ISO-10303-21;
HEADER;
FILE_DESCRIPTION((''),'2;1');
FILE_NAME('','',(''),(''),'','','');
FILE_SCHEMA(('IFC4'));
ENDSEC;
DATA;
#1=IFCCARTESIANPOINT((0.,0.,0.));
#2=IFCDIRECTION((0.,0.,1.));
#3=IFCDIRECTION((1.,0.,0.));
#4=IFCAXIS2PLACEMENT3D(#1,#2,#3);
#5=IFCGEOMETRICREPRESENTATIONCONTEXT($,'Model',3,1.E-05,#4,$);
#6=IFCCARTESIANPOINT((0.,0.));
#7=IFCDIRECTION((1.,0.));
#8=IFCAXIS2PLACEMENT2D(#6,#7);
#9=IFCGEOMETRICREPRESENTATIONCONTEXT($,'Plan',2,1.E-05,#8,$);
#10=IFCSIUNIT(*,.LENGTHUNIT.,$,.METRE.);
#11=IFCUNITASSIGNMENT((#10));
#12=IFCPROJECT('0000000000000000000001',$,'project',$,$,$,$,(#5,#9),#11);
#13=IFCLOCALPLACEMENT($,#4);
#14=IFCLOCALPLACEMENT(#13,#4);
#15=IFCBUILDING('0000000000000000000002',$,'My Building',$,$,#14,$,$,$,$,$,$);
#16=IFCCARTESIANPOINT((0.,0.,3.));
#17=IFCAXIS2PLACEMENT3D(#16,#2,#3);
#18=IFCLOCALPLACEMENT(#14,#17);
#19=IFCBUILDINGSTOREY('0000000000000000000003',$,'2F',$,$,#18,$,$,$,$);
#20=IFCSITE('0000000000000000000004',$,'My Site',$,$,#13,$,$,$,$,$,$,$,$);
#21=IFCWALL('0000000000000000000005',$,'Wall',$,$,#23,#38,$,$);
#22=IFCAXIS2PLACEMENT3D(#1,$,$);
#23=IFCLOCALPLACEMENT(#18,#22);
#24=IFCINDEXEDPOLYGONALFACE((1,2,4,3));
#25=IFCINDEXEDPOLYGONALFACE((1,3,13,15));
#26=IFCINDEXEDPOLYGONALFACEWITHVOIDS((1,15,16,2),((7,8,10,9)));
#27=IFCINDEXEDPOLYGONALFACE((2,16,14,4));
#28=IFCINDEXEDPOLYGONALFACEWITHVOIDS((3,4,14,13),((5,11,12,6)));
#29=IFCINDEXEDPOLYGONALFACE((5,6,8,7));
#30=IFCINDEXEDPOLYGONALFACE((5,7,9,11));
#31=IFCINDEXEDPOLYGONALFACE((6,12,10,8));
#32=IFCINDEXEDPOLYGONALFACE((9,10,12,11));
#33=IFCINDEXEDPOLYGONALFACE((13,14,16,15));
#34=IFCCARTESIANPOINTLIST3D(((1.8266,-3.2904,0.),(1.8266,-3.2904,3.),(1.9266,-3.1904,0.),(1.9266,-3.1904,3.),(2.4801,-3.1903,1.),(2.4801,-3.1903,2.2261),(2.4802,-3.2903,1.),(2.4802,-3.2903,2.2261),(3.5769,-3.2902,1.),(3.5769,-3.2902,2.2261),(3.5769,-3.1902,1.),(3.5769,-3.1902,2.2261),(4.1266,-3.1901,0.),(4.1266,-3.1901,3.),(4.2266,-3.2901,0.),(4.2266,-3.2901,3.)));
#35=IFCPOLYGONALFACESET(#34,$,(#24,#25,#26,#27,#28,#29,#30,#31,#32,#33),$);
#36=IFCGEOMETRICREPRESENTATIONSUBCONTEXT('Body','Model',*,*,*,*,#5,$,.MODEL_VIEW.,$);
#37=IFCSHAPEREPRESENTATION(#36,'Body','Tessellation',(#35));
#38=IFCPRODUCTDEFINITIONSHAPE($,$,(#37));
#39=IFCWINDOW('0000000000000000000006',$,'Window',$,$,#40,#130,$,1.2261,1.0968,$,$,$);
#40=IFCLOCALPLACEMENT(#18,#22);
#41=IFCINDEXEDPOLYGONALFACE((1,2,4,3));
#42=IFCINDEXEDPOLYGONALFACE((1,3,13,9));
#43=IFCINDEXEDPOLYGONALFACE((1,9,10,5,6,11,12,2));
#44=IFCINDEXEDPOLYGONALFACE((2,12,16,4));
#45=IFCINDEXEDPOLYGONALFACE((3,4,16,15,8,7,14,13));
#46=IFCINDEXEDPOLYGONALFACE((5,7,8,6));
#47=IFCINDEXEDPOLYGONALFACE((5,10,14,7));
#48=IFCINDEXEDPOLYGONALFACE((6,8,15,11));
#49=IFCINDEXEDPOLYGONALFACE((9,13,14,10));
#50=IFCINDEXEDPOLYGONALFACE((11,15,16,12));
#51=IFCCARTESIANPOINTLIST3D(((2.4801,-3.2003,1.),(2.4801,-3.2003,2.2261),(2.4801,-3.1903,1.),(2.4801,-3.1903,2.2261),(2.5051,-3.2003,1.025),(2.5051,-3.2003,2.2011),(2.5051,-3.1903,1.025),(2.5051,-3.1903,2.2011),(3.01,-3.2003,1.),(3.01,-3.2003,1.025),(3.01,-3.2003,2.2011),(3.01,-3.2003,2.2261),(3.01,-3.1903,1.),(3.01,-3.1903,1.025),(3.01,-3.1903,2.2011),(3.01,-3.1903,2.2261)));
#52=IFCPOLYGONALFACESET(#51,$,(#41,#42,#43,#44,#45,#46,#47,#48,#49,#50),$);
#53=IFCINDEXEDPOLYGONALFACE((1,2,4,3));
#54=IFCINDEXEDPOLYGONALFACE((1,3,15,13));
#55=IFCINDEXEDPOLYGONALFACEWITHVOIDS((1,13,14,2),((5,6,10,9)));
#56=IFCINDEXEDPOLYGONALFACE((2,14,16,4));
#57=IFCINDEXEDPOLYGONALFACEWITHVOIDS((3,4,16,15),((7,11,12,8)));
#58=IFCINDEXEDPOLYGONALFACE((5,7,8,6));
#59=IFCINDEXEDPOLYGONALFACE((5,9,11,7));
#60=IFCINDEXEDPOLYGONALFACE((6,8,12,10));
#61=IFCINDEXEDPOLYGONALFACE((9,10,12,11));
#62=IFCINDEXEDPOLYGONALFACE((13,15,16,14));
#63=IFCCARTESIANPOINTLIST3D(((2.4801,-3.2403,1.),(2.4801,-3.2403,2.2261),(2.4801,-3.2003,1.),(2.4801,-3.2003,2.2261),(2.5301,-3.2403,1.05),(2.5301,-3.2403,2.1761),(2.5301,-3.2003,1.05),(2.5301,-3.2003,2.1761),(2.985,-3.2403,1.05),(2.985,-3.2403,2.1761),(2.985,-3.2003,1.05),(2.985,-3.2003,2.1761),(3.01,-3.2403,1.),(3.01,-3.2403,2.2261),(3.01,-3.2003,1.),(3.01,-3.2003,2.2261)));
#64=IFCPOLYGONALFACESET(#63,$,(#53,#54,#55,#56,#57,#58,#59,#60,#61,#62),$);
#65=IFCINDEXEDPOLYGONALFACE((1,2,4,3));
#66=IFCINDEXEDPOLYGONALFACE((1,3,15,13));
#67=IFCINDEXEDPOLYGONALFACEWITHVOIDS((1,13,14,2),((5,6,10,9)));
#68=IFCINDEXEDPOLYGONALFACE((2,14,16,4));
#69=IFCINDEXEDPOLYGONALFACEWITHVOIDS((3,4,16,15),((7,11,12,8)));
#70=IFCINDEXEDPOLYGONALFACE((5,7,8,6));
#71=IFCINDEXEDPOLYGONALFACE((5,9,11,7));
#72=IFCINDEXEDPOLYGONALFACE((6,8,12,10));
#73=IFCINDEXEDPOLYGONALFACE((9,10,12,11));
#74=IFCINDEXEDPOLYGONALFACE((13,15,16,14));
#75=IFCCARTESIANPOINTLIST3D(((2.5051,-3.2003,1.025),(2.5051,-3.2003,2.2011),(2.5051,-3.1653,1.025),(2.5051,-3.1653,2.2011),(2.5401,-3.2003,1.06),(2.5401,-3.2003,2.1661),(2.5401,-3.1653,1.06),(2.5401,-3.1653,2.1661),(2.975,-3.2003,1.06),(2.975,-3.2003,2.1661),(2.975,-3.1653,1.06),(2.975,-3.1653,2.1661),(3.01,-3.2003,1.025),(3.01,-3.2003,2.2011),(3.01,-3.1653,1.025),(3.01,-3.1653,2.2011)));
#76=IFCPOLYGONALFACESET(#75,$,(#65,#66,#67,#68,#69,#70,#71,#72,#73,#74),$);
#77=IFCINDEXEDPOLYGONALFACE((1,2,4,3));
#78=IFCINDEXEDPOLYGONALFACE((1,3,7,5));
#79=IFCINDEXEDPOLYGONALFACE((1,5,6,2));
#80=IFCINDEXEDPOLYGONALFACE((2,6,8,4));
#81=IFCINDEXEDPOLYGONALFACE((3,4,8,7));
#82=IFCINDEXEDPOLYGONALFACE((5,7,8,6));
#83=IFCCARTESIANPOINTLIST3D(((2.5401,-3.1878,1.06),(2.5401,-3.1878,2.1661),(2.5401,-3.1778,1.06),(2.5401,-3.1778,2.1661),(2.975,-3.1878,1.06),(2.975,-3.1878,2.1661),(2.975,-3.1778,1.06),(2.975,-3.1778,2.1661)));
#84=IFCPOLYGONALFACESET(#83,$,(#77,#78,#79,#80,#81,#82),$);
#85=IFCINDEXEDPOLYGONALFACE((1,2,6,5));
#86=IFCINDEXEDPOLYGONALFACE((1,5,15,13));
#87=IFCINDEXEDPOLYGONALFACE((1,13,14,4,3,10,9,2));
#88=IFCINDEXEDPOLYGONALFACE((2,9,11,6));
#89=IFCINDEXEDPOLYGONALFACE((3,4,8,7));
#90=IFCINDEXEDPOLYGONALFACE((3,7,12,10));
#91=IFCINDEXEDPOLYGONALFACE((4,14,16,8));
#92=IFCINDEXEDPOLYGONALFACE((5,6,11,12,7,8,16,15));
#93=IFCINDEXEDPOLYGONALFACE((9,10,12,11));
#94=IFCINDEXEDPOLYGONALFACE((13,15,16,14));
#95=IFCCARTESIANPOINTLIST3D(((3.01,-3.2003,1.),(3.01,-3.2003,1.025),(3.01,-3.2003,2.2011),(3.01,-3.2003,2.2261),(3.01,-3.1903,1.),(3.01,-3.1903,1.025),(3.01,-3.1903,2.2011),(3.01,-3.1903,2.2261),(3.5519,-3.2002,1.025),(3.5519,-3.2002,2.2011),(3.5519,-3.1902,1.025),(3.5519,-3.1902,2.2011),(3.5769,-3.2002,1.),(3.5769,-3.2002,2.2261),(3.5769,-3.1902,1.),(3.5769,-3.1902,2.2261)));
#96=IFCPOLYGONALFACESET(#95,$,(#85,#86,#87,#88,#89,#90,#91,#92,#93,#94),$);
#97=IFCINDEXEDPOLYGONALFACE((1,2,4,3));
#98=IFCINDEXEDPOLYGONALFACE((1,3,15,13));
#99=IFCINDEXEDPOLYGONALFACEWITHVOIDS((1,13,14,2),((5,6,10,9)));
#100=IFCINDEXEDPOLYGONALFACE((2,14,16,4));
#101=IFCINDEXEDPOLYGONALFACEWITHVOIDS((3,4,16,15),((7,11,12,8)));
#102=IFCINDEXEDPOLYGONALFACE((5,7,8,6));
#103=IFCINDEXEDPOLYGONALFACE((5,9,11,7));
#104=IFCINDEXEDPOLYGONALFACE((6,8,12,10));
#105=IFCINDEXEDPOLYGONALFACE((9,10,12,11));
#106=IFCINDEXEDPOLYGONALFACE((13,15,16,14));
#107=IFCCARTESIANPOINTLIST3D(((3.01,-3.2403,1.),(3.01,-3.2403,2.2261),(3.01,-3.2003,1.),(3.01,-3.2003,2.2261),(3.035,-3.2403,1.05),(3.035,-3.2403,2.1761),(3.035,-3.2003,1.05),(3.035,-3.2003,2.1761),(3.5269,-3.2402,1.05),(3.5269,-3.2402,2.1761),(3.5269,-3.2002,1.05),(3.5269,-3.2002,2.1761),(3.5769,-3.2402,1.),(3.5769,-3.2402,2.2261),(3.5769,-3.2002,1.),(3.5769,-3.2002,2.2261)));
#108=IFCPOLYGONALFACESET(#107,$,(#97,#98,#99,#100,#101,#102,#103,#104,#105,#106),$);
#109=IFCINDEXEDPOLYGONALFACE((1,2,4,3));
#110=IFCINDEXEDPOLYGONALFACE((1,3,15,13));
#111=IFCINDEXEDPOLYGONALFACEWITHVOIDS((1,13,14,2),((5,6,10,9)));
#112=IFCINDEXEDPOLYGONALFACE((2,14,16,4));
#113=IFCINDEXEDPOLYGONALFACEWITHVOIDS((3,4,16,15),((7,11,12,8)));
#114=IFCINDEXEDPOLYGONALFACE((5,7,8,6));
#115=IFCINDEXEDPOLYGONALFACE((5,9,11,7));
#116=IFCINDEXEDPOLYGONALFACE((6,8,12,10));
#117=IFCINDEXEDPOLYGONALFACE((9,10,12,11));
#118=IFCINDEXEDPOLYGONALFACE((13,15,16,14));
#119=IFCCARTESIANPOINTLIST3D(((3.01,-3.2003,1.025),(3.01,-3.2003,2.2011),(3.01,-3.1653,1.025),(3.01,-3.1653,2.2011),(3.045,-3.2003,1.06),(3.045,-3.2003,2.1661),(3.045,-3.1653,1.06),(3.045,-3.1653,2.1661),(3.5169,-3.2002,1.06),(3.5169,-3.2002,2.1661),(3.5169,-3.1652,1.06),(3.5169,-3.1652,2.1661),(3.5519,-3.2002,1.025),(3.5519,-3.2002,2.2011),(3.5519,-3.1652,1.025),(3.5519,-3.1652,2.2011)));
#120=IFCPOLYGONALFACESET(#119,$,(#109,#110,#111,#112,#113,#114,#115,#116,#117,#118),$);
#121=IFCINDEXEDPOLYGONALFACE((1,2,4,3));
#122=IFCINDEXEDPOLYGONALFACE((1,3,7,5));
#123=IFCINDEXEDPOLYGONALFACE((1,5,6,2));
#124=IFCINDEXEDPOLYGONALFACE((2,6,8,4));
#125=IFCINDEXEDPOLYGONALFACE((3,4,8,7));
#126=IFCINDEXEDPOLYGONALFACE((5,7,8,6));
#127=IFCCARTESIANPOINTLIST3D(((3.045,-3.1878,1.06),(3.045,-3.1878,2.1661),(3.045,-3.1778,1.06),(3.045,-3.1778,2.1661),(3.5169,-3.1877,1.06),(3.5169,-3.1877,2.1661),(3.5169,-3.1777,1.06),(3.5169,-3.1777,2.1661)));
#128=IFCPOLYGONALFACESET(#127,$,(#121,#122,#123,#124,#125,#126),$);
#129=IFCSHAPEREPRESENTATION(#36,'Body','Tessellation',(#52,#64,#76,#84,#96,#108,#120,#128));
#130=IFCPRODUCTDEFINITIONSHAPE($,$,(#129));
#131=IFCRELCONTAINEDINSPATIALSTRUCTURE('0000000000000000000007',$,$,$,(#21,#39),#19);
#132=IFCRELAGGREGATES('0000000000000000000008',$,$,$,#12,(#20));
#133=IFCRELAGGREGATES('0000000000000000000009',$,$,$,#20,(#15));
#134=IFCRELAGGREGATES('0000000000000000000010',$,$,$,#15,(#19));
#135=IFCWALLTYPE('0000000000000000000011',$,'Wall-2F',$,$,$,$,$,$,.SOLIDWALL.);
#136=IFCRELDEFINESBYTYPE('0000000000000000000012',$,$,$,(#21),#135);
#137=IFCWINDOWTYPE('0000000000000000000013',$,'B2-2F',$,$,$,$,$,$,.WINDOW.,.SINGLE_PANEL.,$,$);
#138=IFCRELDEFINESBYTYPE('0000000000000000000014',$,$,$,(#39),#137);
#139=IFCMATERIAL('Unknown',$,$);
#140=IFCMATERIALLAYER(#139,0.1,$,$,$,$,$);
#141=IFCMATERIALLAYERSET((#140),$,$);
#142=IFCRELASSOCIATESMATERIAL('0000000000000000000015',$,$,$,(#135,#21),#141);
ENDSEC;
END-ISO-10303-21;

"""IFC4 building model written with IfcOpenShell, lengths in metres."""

from ifc_helpers import new_model, entity, si_unit, frame, origin_with_axes, origin_2d_with_axis, place, context, subcontext, project, spatial, line, indexed_curve, outline, extrude, shape, source, transform, mapped, material, layer, layer_set, layer_usage, type_object, type_shapes, element, fill, save


model = new_model("IFC4")

# Units and contexts
model_context = context("Model", 3, precision=1e-05, world=origin_with_axes())
plan_context = context("Plan", 2, precision=1e-05, world=origin_2d_with_axis())
body_context_1 = subcontext(model_context, "Body", "Model", "MODEL_VIEW")
body_context_2 = subcontext(plan_context, "Body", "Plan", "PLAN_VIEW")
ifc_project = project(units=[si_unit("LENGTHUNIT", "METRE")], contexts=[model_context, plan_context])

# Site, building, storey
site_placement = place(None, origin_with_axes())
site = spatial("IfcSite", under=ifc_project, at=site_placement, Name="My Site")
building_placement = place(site_placement, origin_with_axes())
building = spatial("IfcBuilding", under=site, at=building_placement, Name="My Building")
storey_placement = place(building_placement, frame((0.0, 0.0, 3.0), z_axis=(0.0, 0.0, 1.0), x_axis=(1.0, 0.0, 0.0)))
storey = spatial("IfcBuildingStorey", under=building, at=storey_placement, Name="2F")

# Shared definitions
ifc_material = material(Name="Unknown")

# Shared definitions
ifc_layer_1 = layer(ifc_material, 0.1)
ifc_layer_set_1 = layer_set([ifc_layer_1])
wall_type = type_object("IfcWallType", Name="Wall-2F", PredefinedType="SOLIDWALL", material=ifc_layer_set_1)

# Shared definitions
shared_shape_1 = source(origin_with_axes(), body_context_1, "Body", "SweptSolid", [
    extrude(outline(indexed_curve([(0.0, 0.0), (1.0968, 0.0), (1.0968, 1.2261), (0.0, 1.2261)], segments=[line(1, 2, 3, 4, 1)])), frame((0.0, -0.6, 0.0), z_axis=(0.0, -1.0, 0.0), x_axis=(1.0, 0.0, 0.0)), (0.0, 0.0, -1.0), 1.2),
])
window_type_1 = type_object("IfcWindowType", Name="B2-2F", PartitioningType="SINGLE_PANEL", PredefinedType="WINDOW")
shared_shape_2 = source(origin_with_axes(), body_context_1, "Body", "SweptSolid", [
    extrude(outline(indexed_curve([(0.5299, 0.0), (0.0, 0.0), (0.0, 1.2261), (0.5299, 1.2261), (0.5299, 1.2011), (0.025, 1.2011), (0.025, 0.025), (0.5299, 0.025)], segments=[line(1, 2, 3, 4, 5, 6, 7, 8, 1)])), frame((0.0, 0.09, 0.0), z_axis=(0.0, -1.0, 0.0), x_axis=(1.0, 0.0, 0.0)), (0.0, 0.0, -1.0), 0.01),
    extrude(outline(indexed_curve([(0.0, 0.0), (0.5299, 0.0), (0.5299, 1.2261), (0.0, 1.2261)], segments=[line(1, 2, 3, 4, 1)]), holes=[indexed_curve([(0.05, 0.05), (0.5049, 0.05), (0.5049, 1.1761), (0.05, 1.1761)], segments=[line(1, 2, 3, 4, 1)])]), frame((0.0, 0.05, 0.0), z_axis=(0.0, -1.0, 0.0), x_axis=(1.0, 0.0, 0.0)), (0.0, 0.0, -1.0), 0.04),
    extrude(outline(indexed_curve([(0.0, 0.0), (0.5049, 0.0), (0.5049, 1.1761), (0.0, 1.1761)], segments=[line(1, 2, 3, 4, 1)]), holes=[indexed_curve([(0.035, 0.035), (0.4699, 0.035), (0.4699, 1.1411), (0.035, 1.1411)], segments=[line(1, 2, 3, 4, 1)])]), frame((0.025, 0.09, 0.025), z_axis=(0.0, -1.0, 0.0), x_axis=(1.0, 0.0, 0.0)), (0.0, 0.0, -1.0), 0.035),
    extrude(outline(indexed_curve([(0.035, 0.035), (0.4699, 0.035), (0.4699, 1.1411), (0.035, 1.1411)], segments=[line(1, 2, 3, 4, 1)])), frame((0.025, 0.1025, 0.025), z_axis=(0.0, -1.0, 0.0), x_axis=(1.0, 0.0, 0.0)), (0.0, 0.0, -1.0), 0.01),
    extrude(outline(indexed_curve([(0.0, 1.2261), (0.5669, 1.2261), (0.5669, 0.0), (0.0, 0.0), (0.0, 0.025), (0.5419, 0.025), (0.5419, 1.2011), (0.0, 1.2011)], segments=[line(1, 2, 3, 4, 5, 6, 7, 8, 1)])), frame((0.5299, 0.09, 0.0), z_axis=(0.0, -1.0, 0.0), x_axis=(1.0, 0.0, 0.0)), (0.0, 0.0, -1.0), 0.01),
    extrude(outline(indexed_curve([(0.0, 0.0), (0.5669, 0.0), (0.5669, 1.2261), (0.0, 1.2261)], segments=[line(1, 2, 3, 4, 1)]), holes=[indexed_curve([(0.025, 0.05), (0.5169, 0.05), (0.5169, 1.1761), (0.025, 1.1761)], segments=[line(1, 2, 3, 4, 1)])]), frame((0.5299, 0.05, 0.0), z_axis=(0.0, -1.0, 0.0), x_axis=(1.0, 0.0, 0.0)), (0.0, 0.0, -1.0), 0.04),
    extrude(outline(indexed_curve([(0.0, 0.0), (0.5419, 0.0), (0.5419, 1.1761), (0.0, 1.1761)], segments=[line(1, 2, 3, 4, 1)]), holes=[indexed_curve([(0.035, 0.035), (0.5069, 0.035), (0.5069, 1.1411), (0.035, 1.1411)], segments=[line(1, 2, 3, 4, 1)])]), frame((0.5299, 0.09, 0.025), z_axis=(0.0, -1.0, 0.0), x_axis=(1.0, 0.0, 0.0)), (0.0, 0.0, -1.0), 0.035),
    extrude(outline(indexed_curve([(0.035, 0.035), (0.5069, 0.035), (0.5069, 1.1411), (0.035, 1.1411)], segments=[line(1, 2, 3, 4, 1)])), frame((0.5299, 0.1025, 0.025), z_axis=(0.0, -1.0, 0.0), x_axis=(1.0, 0.0, 0.0)), (0.0, 0.0, -1.0), 0.01),
])
shared_shape_3 = source(origin_with_axes(), body_context_2, "Body", "Curve2D", [
    entity("IfcIndexedPolyCurve", entity("IfcCartesianPointList2D", [[0.05, 0.05], [0.5049, 0.05]])),
    entity("IfcIndexedPolyCurve", entity("IfcCartesianPointList2D", [[0.0, 0.1], [0.025, 0.1], [0.025, 0.09], [0.05, 0.09], [0.05, 0.05], [0.0, 0.05]]), [entity("IfcLineIndex", [1, 2, 3, 4, 5, 6, 1])]),
    entity("IfcIndexedPolyCurve", entity("IfcCartesianPointList2D", [[0.5299, 0.1], [0.5299, 0.1], [0.5299, 0.09], [0.5049, 0.09], [0.5049, 0.05], [0.5299, 0.05]])),
    entity("IfcIndexedPolyCurve", entity("IfcCartesianPointList2D", [[0.025, 0.09], [0.06, 0.09], [0.06, 0.125], [0.025, 0.125]]), [entity("IfcLineIndex", [1, 2, 3, 4, 1])]),
    entity("IfcIndexedPolyCurve", entity("IfcCartesianPointList2D", [[0.5299, 0.09], [0.4949, 0.09], [0.4949, 0.125], [0.5299, 0.125]]), [entity("IfcLineIndex", [1, 2, 3, 4, 1])]),
    entity("IfcIndexedPolyCurve", entity("IfcCartesianPointList2D", [[0.06, 0.09], [0.4949, 0.09]])),
    entity("IfcIndexedPolyCurve", entity("IfcCartesianPointList2D", [[0.06, 0.125], [0.4949, 0.125]])),
    entity("IfcIndexedPolyCurve", entity("IfcCartesianPointList2D", [[0.06, 0.1075], [0.4949, 0.1075]])),
    entity("IfcIndexedPolyCurve", entity("IfcCartesianPointList2D", [[0.5549, 0.05], [1.0468, 0.05]])),
    entity("IfcIndexedPolyCurve", entity("IfcCartesianPointList2D", [[0.5299, 0.1], [0.5299, 0.1], [0.5299, 0.09], [0.5549, 0.09], [0.5549, 0.05], [0.5299, 0.05]])),
    entity("IfcIndexedPolyCurve", entity("IfcCartesianPointList2D", [[1.0968, 0.1], [1.0718, 0.1], [1.0718, 0.09], [1.0468, 0.09], [1.0468, 0.05], [1.0968, 0.05]]), [entity("IfcLineIndex", [1, 2, 3, 4, 5, 6, 1])]),
    entity("IfcIndexedPolyCurve", entity("IfcCartesianPointList2D", [[0.5299, 0.09], [0.5649, 0.09], [0.5649, 0.125], [0.5299, 0.125]]), [entity("IfcLineIndex", [1, 2, 3, 4, 1])]),
    entity("IfcIndexedPolyCurve", entity("IfcCartesianPointList2D", [[1.0718, 0.09], [1.0368, 0.09], [1.0368, 0.125], [1.0718, 0.125]]), [entity("IfcLineIndex", [1, 2, 3, 4, 1])]),
    entity("IfcIndexedPolyCurve", entity("IfcCartesianPointList2D", [[0.5649, 0.09], [1.0368, 0.09]])),
    entity("IfcIndexedPolyCurve", entity("IfcCartesianPointList2D", [[0.5649, 0.125], [1.0368, 0.125]])),
    entity("IfcIndexedPolyCurve", entity("IfcCartesianPointList2D", [[0.5649, 0.1075], [1.0368, 0.1075]])),
])
type_shapes(window_type_1, [shared_shape_2, shared_shape_3])

# Wall, opening, window
ifc_layer_usage_1 = layer_usage(ifc_layer_set_1, "AXIS2", "POSITIVE", 0.0)
wall_1_placement = place(storey_placement, frame((1.8266, -3.2904, 0.0), z_axis=(0.0, 0.0, 1.0), x_axis=(1.0, 0.000132, 0.0)))
wall_1 = element("IfcWall", 1, at=wall_1_placement, inside=storey, type_object=wall_type, material=ifc_layer_usage_1, Name="Wall", context=body_context_1, shape_type="SweptSolid", body=[
    extrude(outline(indexed_curve([(0.0, 0.0), (0.1, 0.1), (2.3, 0.1), (2.4, 0.0)], segments=[line(1, 2, 3, 4, 1)])), origin_with_axes(), (0.0, 0.0, 1.0), 3.0),
])
opening_1_placement = place(wall_1_placement, frame((0.6535, 0.0, 1.0), z_axis=(0.0, 0.0, 1.0), x_axis=(1.0, 0.0, 0.0)))
opening_1 = element("IfcOpeningElement", 2, at=opening_1_placement, cuts=wall_1, PredefinedType="OPENING", context=body_context_1, shape_type="MappedRepresentation", body=[
    mapped(shared_shape_1, transform((0.0, 0.0, 0.0), x_axis=(1.0, 0.0, 0.0), y_axis=(0.0, 1.0, 0.0), z_axis=(0.0, 0.0, 1.0), scale=1.0)),
])
window_1_placement = place(opening_1_placement, origin_with_axes())
window_1 = element("IfcWindow", 3, at=window_1_placement, inside=storey, type_object=window_type_1, Name="Window", OverallHeight=1.2261, OverallWidth=1.0968, shapes=[
    shape(body_context_1, "Body", "MappedRepresentation", [mapped(shared_shape_2, transform((0.0, 0.0, 0.0), x_axis=(1.0, 0.0, 0.0), y_axis=(0.0, 1.0, 0.0), z_axis=(0.0, 0.0, 1.0), scale=1.0))]),
    shape(body_context_2, "Body", "MappedRepresentation", [mapped(shared_shape_3, transform((0.0, 0.0, 0.0), x_axis=(1.0, 0.0, 0.0), y_axis=(0.0, 1.0, 0.0), z_axis=(0.0, 0.0, 1.0), scale=1.0))]),
])
fill(opening_1, window_1)

save(model, "model.ifc")
